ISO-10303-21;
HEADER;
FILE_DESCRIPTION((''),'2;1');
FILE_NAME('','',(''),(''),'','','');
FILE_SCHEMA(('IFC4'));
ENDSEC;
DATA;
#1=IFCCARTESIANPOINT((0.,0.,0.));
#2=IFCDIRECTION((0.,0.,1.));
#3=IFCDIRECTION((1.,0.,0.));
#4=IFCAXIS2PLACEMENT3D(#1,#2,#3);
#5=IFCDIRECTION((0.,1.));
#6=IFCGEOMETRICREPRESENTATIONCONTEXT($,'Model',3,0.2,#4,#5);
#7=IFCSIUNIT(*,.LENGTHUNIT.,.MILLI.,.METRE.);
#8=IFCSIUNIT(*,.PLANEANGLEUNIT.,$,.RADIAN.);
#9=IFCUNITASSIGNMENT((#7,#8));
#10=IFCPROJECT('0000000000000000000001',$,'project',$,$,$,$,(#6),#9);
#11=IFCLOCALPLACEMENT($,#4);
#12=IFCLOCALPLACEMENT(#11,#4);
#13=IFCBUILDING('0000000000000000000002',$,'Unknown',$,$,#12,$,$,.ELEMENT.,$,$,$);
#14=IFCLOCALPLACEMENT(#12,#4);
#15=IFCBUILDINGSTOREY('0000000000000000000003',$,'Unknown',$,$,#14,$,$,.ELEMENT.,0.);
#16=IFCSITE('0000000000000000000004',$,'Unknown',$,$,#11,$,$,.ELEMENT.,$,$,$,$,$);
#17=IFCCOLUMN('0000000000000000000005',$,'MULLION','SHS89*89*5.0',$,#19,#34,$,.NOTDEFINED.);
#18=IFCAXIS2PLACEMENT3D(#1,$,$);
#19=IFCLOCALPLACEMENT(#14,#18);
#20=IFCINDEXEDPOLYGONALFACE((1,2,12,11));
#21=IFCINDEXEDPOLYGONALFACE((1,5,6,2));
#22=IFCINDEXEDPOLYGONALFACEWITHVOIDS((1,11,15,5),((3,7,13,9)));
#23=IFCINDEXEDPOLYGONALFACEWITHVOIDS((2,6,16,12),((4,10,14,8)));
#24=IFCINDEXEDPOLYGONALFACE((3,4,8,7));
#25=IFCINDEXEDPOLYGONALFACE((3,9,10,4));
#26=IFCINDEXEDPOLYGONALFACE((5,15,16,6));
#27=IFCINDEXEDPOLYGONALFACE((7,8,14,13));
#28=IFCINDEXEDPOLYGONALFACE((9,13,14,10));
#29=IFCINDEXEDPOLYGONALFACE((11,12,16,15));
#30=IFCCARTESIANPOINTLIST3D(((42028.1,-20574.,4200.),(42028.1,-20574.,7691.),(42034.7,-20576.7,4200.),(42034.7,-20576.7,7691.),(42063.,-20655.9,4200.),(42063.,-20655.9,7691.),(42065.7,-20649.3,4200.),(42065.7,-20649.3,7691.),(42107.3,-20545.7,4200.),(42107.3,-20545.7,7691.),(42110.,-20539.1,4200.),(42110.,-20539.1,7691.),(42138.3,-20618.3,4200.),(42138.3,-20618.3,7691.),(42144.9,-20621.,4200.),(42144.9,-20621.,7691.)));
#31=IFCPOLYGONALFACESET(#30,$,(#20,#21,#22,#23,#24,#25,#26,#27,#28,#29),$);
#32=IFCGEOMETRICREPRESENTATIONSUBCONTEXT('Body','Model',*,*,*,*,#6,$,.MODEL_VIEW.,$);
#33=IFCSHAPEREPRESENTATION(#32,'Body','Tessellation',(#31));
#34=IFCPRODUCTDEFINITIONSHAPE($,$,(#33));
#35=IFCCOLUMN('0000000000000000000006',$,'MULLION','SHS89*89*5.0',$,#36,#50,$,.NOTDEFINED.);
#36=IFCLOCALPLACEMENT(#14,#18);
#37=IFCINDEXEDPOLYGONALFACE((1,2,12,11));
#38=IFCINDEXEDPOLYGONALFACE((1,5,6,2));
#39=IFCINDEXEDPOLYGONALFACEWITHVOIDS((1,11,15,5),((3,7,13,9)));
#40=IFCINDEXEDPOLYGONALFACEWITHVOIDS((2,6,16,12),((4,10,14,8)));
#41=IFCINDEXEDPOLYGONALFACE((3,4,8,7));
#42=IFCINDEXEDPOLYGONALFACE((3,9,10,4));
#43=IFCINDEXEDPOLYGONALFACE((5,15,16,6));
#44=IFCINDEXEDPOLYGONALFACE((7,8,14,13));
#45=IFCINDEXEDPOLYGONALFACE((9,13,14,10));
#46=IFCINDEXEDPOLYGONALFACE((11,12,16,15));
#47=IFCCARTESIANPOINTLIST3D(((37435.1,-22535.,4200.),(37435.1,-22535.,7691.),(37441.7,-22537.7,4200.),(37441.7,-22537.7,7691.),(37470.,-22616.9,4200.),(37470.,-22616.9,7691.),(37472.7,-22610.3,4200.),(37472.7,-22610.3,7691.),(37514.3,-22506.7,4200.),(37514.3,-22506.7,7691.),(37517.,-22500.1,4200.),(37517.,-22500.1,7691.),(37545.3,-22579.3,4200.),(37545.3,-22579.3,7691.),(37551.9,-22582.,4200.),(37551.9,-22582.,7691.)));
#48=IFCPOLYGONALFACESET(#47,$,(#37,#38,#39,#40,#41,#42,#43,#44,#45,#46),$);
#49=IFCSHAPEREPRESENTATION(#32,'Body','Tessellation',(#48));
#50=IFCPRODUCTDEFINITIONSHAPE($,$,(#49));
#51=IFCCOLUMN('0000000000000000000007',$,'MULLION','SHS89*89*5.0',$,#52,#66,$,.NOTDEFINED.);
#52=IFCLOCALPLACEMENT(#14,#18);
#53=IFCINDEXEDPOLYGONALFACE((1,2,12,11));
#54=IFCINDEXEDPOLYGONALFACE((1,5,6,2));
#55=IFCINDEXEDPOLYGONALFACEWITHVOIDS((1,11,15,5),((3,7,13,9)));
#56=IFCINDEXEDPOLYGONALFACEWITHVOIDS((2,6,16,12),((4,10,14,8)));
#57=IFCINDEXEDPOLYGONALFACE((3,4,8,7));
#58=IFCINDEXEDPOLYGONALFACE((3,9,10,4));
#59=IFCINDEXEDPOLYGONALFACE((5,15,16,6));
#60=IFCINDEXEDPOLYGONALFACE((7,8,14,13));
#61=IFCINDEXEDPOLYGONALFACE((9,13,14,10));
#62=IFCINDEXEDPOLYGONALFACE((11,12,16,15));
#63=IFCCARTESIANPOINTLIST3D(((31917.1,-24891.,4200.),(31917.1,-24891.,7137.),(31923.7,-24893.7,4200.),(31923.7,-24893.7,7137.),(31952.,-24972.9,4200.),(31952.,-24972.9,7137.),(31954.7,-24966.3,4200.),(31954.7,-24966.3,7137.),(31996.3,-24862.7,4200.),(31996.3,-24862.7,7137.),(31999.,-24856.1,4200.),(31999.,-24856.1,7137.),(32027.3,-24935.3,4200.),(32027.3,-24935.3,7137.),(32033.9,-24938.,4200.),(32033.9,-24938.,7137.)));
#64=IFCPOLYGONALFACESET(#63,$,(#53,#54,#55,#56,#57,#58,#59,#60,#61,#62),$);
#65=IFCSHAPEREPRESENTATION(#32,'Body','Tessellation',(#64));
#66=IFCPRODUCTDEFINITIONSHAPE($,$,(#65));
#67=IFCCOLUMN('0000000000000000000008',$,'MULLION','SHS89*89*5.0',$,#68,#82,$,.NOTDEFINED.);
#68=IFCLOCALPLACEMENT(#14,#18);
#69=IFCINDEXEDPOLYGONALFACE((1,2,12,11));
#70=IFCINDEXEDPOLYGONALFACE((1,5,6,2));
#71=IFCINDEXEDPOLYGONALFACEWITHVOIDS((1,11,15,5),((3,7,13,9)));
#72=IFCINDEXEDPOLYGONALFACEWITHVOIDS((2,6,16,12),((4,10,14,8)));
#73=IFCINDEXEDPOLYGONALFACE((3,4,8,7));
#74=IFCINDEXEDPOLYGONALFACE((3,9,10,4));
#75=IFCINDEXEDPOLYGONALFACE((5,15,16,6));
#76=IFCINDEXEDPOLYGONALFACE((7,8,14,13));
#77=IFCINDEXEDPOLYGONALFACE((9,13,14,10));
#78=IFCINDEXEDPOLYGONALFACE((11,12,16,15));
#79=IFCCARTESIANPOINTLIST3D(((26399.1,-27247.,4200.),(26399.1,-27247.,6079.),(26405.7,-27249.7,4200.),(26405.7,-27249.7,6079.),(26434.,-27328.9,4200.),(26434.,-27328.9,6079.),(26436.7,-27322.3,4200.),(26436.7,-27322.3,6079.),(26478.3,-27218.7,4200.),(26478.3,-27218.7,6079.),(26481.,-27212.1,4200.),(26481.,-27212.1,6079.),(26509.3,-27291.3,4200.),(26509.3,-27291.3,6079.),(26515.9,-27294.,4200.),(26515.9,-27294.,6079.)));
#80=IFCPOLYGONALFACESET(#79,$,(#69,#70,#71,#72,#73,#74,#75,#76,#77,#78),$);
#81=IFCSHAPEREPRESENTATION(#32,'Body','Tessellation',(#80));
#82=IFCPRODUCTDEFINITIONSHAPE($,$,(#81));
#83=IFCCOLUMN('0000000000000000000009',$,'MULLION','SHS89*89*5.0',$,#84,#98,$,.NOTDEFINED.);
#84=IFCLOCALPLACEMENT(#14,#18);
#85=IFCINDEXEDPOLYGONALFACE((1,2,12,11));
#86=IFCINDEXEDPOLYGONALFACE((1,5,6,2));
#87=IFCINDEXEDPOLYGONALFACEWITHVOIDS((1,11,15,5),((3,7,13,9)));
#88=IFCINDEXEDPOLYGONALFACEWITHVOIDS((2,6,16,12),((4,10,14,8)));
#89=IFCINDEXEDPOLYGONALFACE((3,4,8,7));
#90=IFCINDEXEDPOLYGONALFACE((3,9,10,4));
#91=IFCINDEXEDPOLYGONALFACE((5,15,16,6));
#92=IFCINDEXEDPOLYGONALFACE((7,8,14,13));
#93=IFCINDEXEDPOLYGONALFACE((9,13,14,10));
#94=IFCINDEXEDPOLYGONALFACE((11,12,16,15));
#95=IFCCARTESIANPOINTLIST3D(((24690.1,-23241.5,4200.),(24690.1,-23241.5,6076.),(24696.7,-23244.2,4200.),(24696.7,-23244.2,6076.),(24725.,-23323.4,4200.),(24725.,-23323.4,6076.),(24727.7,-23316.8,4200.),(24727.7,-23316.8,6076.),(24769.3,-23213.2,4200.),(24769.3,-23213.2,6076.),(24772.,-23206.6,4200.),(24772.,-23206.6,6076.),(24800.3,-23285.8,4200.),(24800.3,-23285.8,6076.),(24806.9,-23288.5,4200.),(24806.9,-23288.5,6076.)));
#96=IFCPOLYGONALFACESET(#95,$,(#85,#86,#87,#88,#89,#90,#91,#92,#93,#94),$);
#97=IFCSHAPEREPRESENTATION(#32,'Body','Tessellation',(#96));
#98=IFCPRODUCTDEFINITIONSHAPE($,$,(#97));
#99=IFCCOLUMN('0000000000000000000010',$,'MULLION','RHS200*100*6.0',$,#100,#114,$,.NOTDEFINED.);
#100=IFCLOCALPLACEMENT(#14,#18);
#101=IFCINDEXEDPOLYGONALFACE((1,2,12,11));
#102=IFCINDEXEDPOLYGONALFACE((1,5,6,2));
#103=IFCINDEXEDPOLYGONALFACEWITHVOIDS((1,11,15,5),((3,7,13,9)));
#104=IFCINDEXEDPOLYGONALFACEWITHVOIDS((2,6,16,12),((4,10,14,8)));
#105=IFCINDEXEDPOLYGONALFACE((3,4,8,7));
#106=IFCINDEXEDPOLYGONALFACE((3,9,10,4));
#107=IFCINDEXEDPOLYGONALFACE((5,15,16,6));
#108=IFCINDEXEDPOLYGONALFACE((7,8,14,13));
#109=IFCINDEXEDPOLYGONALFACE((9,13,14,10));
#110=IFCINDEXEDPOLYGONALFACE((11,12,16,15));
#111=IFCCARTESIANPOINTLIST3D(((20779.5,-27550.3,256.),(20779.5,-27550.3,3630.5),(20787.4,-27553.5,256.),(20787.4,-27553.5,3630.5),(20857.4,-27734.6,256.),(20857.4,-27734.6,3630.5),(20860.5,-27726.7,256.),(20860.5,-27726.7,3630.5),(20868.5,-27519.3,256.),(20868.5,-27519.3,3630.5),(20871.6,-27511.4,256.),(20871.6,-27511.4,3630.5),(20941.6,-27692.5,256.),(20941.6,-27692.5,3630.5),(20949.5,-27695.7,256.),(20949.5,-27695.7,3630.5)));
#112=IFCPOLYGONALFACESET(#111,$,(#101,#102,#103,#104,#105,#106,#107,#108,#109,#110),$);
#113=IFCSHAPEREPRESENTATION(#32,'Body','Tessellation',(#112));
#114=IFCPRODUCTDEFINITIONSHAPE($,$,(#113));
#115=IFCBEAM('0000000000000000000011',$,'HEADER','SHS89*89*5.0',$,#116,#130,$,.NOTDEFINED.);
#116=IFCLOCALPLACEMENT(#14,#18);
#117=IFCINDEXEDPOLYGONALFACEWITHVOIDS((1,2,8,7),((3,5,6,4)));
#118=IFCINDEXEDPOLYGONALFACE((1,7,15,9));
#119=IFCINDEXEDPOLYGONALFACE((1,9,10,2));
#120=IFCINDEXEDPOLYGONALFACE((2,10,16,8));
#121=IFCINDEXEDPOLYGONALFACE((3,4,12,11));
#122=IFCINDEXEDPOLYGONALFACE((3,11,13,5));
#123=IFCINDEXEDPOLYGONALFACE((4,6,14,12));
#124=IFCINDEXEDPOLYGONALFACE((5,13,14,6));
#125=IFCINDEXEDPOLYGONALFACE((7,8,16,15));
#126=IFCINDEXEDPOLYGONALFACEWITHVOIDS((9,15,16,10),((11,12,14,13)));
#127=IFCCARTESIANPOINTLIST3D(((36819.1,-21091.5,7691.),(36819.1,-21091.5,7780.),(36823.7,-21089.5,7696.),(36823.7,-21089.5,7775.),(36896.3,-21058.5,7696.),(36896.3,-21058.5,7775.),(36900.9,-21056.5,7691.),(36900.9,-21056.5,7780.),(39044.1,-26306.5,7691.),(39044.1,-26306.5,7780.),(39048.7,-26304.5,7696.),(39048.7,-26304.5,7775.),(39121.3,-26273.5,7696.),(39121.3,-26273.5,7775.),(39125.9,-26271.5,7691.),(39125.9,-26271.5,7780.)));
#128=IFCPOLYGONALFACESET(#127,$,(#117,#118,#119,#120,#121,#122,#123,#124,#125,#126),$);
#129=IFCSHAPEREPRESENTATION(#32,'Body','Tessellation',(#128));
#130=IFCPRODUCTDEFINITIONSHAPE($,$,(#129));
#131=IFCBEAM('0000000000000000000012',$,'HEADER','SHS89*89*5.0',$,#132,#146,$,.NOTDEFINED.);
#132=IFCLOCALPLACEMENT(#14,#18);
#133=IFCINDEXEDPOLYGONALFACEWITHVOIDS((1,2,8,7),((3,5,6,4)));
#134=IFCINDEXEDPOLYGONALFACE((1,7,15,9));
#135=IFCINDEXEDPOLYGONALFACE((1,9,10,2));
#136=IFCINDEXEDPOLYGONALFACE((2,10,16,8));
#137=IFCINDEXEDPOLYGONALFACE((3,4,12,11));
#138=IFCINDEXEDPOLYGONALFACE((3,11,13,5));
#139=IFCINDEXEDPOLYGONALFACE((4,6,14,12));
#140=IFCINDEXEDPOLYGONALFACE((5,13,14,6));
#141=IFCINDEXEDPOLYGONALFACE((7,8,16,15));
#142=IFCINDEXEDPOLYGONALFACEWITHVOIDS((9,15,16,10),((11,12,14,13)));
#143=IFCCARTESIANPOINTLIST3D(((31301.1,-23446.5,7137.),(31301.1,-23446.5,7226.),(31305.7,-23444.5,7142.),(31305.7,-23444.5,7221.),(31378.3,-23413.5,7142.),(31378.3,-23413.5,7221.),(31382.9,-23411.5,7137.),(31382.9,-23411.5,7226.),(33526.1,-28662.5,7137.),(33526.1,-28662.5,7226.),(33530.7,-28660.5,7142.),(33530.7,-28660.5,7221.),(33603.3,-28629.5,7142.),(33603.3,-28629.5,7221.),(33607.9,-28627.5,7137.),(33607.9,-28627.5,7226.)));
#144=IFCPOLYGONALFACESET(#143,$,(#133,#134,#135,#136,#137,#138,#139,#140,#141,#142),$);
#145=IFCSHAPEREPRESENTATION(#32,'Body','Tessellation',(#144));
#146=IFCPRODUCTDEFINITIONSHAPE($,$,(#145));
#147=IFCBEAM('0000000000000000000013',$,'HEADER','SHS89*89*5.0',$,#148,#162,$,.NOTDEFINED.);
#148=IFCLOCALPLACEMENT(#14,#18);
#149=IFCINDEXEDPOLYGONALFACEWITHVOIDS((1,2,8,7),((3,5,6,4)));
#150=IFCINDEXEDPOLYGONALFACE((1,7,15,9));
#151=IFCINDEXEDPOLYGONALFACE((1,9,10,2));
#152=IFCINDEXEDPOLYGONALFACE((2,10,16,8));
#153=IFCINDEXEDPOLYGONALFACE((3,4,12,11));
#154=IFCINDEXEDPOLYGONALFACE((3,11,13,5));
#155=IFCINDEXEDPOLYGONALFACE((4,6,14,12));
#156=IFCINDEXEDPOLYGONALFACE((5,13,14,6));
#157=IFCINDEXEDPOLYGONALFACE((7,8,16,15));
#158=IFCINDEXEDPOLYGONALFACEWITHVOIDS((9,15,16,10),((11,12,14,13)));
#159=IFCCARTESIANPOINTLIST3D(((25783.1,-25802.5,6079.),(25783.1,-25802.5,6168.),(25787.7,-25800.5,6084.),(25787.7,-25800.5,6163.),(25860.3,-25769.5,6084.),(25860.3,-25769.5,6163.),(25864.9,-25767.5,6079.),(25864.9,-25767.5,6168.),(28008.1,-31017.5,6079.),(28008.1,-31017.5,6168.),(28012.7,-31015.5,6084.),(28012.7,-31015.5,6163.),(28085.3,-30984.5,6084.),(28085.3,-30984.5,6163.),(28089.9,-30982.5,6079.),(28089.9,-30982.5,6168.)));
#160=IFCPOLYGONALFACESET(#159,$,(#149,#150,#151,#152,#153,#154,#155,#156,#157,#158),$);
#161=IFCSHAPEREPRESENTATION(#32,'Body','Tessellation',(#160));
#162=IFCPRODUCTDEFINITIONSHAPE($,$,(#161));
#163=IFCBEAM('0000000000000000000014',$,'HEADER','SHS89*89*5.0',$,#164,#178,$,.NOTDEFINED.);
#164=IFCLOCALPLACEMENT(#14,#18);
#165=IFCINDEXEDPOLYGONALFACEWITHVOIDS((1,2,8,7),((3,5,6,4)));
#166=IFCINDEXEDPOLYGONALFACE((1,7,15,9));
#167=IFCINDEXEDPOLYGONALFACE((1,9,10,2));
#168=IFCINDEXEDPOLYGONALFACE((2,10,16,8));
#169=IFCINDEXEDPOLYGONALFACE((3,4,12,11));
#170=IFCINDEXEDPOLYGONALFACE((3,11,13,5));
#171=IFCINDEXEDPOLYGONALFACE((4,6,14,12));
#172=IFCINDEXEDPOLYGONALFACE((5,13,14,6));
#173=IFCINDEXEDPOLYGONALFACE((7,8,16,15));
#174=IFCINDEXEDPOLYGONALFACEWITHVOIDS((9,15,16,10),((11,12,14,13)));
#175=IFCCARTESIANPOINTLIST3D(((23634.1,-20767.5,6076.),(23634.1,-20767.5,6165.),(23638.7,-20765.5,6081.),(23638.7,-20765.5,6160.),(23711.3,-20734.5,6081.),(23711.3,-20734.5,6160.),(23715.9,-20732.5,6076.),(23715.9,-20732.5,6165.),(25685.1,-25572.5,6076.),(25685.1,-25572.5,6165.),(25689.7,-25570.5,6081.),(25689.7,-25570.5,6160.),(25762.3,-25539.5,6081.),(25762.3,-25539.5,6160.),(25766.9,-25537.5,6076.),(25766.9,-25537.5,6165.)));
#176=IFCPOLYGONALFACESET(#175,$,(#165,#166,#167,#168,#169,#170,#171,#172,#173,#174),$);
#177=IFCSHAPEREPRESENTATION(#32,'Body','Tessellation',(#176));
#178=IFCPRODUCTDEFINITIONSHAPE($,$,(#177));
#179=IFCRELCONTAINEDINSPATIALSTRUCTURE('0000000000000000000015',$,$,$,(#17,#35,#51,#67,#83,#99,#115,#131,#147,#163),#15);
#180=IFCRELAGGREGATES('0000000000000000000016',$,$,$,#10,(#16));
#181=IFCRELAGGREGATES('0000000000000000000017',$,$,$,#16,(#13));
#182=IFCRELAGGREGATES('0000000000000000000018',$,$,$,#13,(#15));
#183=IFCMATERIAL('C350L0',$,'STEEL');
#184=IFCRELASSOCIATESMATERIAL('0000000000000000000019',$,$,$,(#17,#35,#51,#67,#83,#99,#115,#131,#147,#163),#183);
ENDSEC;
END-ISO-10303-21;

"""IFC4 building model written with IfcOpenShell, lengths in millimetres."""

from ifc_helpers import new_model, si_unit, direction, frame, origin_with_axes, place, context, subcontext, project, spatial, line, indexed_curve, outline, extrude, material, element, save


model = new_model("IFC4")

# Units and contexts
model_context = context("Model", 3, precision=0.2, world=origin_with_axes(), true_north=direction((0.0, 1.0)))
body_context = subcontext(model_context, "Body", "Model", "MODEL_VIEW")
ifc_project = project(units=[si_unit("LENGTHUNIT", "METRE", prefix="MILLI"), si_unit("PLANEANGLEUNIT", "RADIAN")], contexts=[model_context])

# Site, building, storey
site_placement = place(None, origin_with_axes())
site = spatial("IfcSite", under=ifc_project, at=site_placement, Name="Unknown", CompositionType="ELEMENT")
building_placement = place(site_placement, origin_with_axes())
building = spatial("IfcBuilding", under=site, at=building_placement, Name="Unknown", CompositionType="ELEMENT")
storey_placement = place(building_placement, origin_with_axes())
storey = spatial("IfcBuildingStorey", under=building, at=storey_placement, Name="Unknown", CompositionType="ELEMENT", Elevation=0.0)

# Columns
ifc_material_1 = material(Name="C350L0", Category="STEEL")
for number, where, z_axis, x_axis, name in (
    (1, (42086.5, -20597.5, 4200.0), (0.919753, 0.392498, 0.0), (0.0, 0.0, 1.0), "MULLION"),
    (2, (37493.5, -22558.5, 4200.0), (0.919753, 0.392498, 0.0), (0.0, 0.0, 1.0), "MULLION"),
):
    element("IfcColumn", number, at=place(storey_placement, frame(where, z_axis=z_axis, x_axis=x_axis)), inside=storey, material=ifc_material_1, Name=name, Description="SHS89*89*5.0", PredefinedType="NOTDEFINED", context=body_context, shape_type="SolidModel", body=[
        extrude(outline(indexed_curve([(-44.5, -44.5), (44.5, -44.5), (44.5, 44.5), (-44.5, 44.5)], segments=[line(1, 2, 3, 4, 1)]), holes=[indexed_curve([(-39.5, -39.5), (-39.5, 39.5), (39.5, 39.5), (39.5, -39.5)], segments=[line(1, 2, 3, 4, 1)])]), frame((0.0, 0.0, 0.0), z_axis=(-1.0, 0.0, 0.0), x_axis=(0.0, 0.0, 1.0)), (0.0, 0.0, -1.0), 3491.0),
    ])
column_1_placement = place(storey_placement, frame((31975.5, -24914.5, 4200.0), z_axis=(0.919821, 0.392337, 0.0), x_axis=(0.0, 0.0, 1.0)))
element("IfcColumn", 3, at=column_1_placement, inside=storey, material=ifc_material_1, Name="MULLION", Description="SHS89*89*5.0", PredefinedType="NOTDEFINED", context=body_context, shape_type="SolidModel", body=[
    extrude(outline(indexed_curve([(-44.5, -44.5), (44.5, -44.5), (44.5, 44.5), (-44.5, 44.5)], segments=[line(1, 2, 3, 4, 1)]), holes=[indexed_curve([(-39.5, -39.5), (-39.5, 39.5), (39.5, 39.5), (39.5, -39.5)], segments=[line(1, 2, 3, 4, 1)])]), frame((0.0, 0.0, 0.0), z_axis=(-1.0, 0.0, 0.0), x_axis=(0.0, 0.0, 1.0)), (0.0, 0.0, -1.0), 2937.0),
])
column_2_placement = place(storey_placement, frame((26457.5, -27270.5, 4200.0), z_axis=(0.919753, 0.392498, 0.0), x_axis=(0.0, 0.0, 1.0)))
element("IfcColumn", 4, at=column_2_placement, inside=storey, material=ifc_material_1, Name="MULLION", Description="SHS89*89*5.0", PredefinedType="NOTDEFINED", context=body_context, shape_type="SolidModel", body=[
    extrude(outline(indexed_curve([(-44.5, -44.5), (44.5, -44.5), (44.5, 44.5), (-44.5, 44.5)], segments=[line(1, 2, 3, 4, 1)]), holes=[indexed_curve([(-39.5, -39.5), (-39.5, 39.5), (39.5, 39.5), (39.5, -39.5)], segments=[line(1, 2, 3, 4, 1)])]), frame((0.0, 0.0, 0.0), z_axis=(-1.0, 0.0, 0.0), x_axis=(0.0, 0.0, 1.0)), (0.0, 0.0, -1.0), 1879.0),
])
column_3_placement = place(storey_placement, frame((24748.5, -23265.0, 4200.0), z_axis=(0.919684, 0.392658, 0.0), x_axis=(0.0, 0.0, 1.0)))
element("IfcColumn", 5, at=column_3_placement, inside=storey, material=ifc_material_1, Name="MULLION", Description="SHS89*89*5.0", PredefinedType="NOTDEFINED", context=body_context, shape_type="SolidModel", body=[
    extrude(outline(indexed_curve([(-44.5, -44.5), (44.5, -44.5), (44.5, 44.5), (-44.5, 44.5)], segments=[line(1, 2, 3, 4, 1)]), holes=[indexed_curve([(-39.5, -39.5), (-39.5, 39.5), (39.5, 39.5), (39.5, -39.5)], segments=[line(1, 2, 3, 4, 1)])]), frame((0.0, 0.0, 0.0), z_axis=(-1.0, 0.0, 0.0), x_axis=(0.0, 0.0, 1.0)), (0.0, 0.0, -1.0), 1876.0),
])
column_4_placement = place(storey_placement, frame((20864.5, -27623.0, 256.0), z_axis=(0.921185, 0.389124, 0.0), x_axis=(0.0, 0.0, 1.0)))
element("IfcColumn", 6, at=column_4_placement, inside=storey, material=ifc_material_1, Name="MULLION", Description="RHS200*100*6.0", PredefinedType="NOTDEFINED", context=body_context, shape_type="SolidModel", body=[
    extrude(outline(indexed_curve([(-50.0, -100.0), (50.0, -100.0), (50.0, 100.0), (-50.0, 100.0)], segments=[line(1, 2, 3, 4, 1)]), holes=[indexed_curve([(-44.0, -94.0), (-44.0, 94.0), (44.0, 94.0), (44.0, -94.0)], segments=[line(1, 2, 3, 4, 1)])]), frame((0.0, 0.0, 0.0), z_axis=(-1.0, 0.0, 0.0), x_axis=(0.0, 0.0, 1.0)), (0.0, 0.0, -1.0), 3374.5),
])

# Beams
beam_1_placement = place(storey_placement, frame((36860.0, -21074.0, 7735.5), z_axis=(0.0, 0.0, 1.0), x_axis=(0.392429, -0.919782, 0.0)))
element("IfcBeam", 7, at=beam_1_placement, inside=storey, material=ifc_material_1, Name="HEADER", Description="SHS89*89*5.0", PredefinedType="NOTDEFINED", context=body_context, shape_type="SolidModel", body=[
    extrude(outline(indexed_curve([(-44.5, -44.5), (44.5, -44.5), (44.5, 44.5), (-44.5, 44.5)], segments=[line(1, 2, 3, 4, 1)]), holes=[indexed_curve([(-39.5, -39.5), (-39.5, 39.5), (39.5, 39.5), (39.5, -39.5)], segments=[line(1, 2, 3, 4, 1)])]), frame((0.0, 0.0, 0.0), z_axis=(-1.0, 0.0, 0.0), x_axis=(0.0, 0.0, 1.0)), (0.0, 0.0, -1.0), 5669.8),
])
beam_2_placement = place(storey_placement, frame((31342.0, -23429.0, 7181.5), z_axis=(0.0, 0.0, 1.0), x_axis=(0.392365, -0.91981, 0.0)))
element("IfcBeam", 8, at=beam_2_placement, inside=storey, material=ifc_material_1, Name="HEADER", Description="SHS89*89*5.0", PredefinedType="NOTDEFINED", context=body_context, shape_type="SolidModel", body=[
    extrude(outline(indexed_curve([(-44.5, -44.5), (44.5, -44.5), (44.5, 44.5), (-44.5, 44.5)], segments=[line(1, 2, 3, 4, 1)]), holes=[indexed_curve([(-39.5, -39.5), (-39.5, 39.5), (39.5, 39.5), (39.5, -39.5)], segments=[line(1, 2, 3, 4, 1)])]), frame((0.0, 0.0, 0.0), z_axis=(-1.0, 0.0, 0.0), x_axis=(0.0, 0.0, 1.0)), (0.0, 0.0, -1.0), 5670.7),
])
beam_3_placement = place(storey_placement, frame((25824.0, -25785.0, 6123.5), z_axis=(0.0, 0.0, 1.0), x_axis=(0.392429, -0.919782, 0.0)))
element("IfcBeam", 9, at=beam_3_placement, inside=storey, material=ifc_material_1, Name="HEADER", Description="SHS89*89*5.0", PredefinedType="NOTDEFINED", context=body_context, shape_type="SolidModel", body=[
    extrude(outline(indexed_curve([(-44.5, -44.5), (44.5, -44.5), (44.5, 44.5), (-44.5, 44.5)], segments=[line(1, 2, 3, 4, 1)]), holes=[indexed_curve([(-39.5, -39.5), (-39.5, 39.5), (39.5, 39.5), (39.5, -39.5)], segments=[line(1, 2, 3, 4, 1)])]), frame((0.0, 0.0, 0.0), z_axis=(-1.0, 0.0, 0.0), x_axis=(0.0, 0.0, 1.0)), (0.0, 0.0, -1.0), 5669.8),
])
beam_4_placement = place(storey_placement, frame((23675.0, -20750.0, 6120.5), z_axis=(0.0, 0.0, 1.0), x_axis=(0.392579, -0.919718, 0.0)))
element("IfcBeam", 10, at=beam_4_placement, inside=storey, material=ifc_material_1, Name="HEADER", Description="SHS89*89*5.0", PredefinedType="NOTDEFINED", context=body_context, shape_type="SolidModel", body=[
    extrude(outline(indexed_curve([(-44.5, -44.5), (44.5, -44.5), (44.5, 44.5), (-44.5, 44.5)], segments=[line(1, 2, 3, 4, 1)]), holes=[indexed_curve([(-39.5, -39.5), (-39.5, 39.5), (39.5, 39.5), (39.5, -39.5)], segments=[line(1, 2, 3, 4, 1)])]), frame((0.0, 0.0, 0.0), z_axis=(-1.0, 0.0, 0.0), x_axis=(0.0, 0.0, 1.0)), (0.0, 0.0, -1.0), 5224.4),
])

save(model, "model.ifc")
